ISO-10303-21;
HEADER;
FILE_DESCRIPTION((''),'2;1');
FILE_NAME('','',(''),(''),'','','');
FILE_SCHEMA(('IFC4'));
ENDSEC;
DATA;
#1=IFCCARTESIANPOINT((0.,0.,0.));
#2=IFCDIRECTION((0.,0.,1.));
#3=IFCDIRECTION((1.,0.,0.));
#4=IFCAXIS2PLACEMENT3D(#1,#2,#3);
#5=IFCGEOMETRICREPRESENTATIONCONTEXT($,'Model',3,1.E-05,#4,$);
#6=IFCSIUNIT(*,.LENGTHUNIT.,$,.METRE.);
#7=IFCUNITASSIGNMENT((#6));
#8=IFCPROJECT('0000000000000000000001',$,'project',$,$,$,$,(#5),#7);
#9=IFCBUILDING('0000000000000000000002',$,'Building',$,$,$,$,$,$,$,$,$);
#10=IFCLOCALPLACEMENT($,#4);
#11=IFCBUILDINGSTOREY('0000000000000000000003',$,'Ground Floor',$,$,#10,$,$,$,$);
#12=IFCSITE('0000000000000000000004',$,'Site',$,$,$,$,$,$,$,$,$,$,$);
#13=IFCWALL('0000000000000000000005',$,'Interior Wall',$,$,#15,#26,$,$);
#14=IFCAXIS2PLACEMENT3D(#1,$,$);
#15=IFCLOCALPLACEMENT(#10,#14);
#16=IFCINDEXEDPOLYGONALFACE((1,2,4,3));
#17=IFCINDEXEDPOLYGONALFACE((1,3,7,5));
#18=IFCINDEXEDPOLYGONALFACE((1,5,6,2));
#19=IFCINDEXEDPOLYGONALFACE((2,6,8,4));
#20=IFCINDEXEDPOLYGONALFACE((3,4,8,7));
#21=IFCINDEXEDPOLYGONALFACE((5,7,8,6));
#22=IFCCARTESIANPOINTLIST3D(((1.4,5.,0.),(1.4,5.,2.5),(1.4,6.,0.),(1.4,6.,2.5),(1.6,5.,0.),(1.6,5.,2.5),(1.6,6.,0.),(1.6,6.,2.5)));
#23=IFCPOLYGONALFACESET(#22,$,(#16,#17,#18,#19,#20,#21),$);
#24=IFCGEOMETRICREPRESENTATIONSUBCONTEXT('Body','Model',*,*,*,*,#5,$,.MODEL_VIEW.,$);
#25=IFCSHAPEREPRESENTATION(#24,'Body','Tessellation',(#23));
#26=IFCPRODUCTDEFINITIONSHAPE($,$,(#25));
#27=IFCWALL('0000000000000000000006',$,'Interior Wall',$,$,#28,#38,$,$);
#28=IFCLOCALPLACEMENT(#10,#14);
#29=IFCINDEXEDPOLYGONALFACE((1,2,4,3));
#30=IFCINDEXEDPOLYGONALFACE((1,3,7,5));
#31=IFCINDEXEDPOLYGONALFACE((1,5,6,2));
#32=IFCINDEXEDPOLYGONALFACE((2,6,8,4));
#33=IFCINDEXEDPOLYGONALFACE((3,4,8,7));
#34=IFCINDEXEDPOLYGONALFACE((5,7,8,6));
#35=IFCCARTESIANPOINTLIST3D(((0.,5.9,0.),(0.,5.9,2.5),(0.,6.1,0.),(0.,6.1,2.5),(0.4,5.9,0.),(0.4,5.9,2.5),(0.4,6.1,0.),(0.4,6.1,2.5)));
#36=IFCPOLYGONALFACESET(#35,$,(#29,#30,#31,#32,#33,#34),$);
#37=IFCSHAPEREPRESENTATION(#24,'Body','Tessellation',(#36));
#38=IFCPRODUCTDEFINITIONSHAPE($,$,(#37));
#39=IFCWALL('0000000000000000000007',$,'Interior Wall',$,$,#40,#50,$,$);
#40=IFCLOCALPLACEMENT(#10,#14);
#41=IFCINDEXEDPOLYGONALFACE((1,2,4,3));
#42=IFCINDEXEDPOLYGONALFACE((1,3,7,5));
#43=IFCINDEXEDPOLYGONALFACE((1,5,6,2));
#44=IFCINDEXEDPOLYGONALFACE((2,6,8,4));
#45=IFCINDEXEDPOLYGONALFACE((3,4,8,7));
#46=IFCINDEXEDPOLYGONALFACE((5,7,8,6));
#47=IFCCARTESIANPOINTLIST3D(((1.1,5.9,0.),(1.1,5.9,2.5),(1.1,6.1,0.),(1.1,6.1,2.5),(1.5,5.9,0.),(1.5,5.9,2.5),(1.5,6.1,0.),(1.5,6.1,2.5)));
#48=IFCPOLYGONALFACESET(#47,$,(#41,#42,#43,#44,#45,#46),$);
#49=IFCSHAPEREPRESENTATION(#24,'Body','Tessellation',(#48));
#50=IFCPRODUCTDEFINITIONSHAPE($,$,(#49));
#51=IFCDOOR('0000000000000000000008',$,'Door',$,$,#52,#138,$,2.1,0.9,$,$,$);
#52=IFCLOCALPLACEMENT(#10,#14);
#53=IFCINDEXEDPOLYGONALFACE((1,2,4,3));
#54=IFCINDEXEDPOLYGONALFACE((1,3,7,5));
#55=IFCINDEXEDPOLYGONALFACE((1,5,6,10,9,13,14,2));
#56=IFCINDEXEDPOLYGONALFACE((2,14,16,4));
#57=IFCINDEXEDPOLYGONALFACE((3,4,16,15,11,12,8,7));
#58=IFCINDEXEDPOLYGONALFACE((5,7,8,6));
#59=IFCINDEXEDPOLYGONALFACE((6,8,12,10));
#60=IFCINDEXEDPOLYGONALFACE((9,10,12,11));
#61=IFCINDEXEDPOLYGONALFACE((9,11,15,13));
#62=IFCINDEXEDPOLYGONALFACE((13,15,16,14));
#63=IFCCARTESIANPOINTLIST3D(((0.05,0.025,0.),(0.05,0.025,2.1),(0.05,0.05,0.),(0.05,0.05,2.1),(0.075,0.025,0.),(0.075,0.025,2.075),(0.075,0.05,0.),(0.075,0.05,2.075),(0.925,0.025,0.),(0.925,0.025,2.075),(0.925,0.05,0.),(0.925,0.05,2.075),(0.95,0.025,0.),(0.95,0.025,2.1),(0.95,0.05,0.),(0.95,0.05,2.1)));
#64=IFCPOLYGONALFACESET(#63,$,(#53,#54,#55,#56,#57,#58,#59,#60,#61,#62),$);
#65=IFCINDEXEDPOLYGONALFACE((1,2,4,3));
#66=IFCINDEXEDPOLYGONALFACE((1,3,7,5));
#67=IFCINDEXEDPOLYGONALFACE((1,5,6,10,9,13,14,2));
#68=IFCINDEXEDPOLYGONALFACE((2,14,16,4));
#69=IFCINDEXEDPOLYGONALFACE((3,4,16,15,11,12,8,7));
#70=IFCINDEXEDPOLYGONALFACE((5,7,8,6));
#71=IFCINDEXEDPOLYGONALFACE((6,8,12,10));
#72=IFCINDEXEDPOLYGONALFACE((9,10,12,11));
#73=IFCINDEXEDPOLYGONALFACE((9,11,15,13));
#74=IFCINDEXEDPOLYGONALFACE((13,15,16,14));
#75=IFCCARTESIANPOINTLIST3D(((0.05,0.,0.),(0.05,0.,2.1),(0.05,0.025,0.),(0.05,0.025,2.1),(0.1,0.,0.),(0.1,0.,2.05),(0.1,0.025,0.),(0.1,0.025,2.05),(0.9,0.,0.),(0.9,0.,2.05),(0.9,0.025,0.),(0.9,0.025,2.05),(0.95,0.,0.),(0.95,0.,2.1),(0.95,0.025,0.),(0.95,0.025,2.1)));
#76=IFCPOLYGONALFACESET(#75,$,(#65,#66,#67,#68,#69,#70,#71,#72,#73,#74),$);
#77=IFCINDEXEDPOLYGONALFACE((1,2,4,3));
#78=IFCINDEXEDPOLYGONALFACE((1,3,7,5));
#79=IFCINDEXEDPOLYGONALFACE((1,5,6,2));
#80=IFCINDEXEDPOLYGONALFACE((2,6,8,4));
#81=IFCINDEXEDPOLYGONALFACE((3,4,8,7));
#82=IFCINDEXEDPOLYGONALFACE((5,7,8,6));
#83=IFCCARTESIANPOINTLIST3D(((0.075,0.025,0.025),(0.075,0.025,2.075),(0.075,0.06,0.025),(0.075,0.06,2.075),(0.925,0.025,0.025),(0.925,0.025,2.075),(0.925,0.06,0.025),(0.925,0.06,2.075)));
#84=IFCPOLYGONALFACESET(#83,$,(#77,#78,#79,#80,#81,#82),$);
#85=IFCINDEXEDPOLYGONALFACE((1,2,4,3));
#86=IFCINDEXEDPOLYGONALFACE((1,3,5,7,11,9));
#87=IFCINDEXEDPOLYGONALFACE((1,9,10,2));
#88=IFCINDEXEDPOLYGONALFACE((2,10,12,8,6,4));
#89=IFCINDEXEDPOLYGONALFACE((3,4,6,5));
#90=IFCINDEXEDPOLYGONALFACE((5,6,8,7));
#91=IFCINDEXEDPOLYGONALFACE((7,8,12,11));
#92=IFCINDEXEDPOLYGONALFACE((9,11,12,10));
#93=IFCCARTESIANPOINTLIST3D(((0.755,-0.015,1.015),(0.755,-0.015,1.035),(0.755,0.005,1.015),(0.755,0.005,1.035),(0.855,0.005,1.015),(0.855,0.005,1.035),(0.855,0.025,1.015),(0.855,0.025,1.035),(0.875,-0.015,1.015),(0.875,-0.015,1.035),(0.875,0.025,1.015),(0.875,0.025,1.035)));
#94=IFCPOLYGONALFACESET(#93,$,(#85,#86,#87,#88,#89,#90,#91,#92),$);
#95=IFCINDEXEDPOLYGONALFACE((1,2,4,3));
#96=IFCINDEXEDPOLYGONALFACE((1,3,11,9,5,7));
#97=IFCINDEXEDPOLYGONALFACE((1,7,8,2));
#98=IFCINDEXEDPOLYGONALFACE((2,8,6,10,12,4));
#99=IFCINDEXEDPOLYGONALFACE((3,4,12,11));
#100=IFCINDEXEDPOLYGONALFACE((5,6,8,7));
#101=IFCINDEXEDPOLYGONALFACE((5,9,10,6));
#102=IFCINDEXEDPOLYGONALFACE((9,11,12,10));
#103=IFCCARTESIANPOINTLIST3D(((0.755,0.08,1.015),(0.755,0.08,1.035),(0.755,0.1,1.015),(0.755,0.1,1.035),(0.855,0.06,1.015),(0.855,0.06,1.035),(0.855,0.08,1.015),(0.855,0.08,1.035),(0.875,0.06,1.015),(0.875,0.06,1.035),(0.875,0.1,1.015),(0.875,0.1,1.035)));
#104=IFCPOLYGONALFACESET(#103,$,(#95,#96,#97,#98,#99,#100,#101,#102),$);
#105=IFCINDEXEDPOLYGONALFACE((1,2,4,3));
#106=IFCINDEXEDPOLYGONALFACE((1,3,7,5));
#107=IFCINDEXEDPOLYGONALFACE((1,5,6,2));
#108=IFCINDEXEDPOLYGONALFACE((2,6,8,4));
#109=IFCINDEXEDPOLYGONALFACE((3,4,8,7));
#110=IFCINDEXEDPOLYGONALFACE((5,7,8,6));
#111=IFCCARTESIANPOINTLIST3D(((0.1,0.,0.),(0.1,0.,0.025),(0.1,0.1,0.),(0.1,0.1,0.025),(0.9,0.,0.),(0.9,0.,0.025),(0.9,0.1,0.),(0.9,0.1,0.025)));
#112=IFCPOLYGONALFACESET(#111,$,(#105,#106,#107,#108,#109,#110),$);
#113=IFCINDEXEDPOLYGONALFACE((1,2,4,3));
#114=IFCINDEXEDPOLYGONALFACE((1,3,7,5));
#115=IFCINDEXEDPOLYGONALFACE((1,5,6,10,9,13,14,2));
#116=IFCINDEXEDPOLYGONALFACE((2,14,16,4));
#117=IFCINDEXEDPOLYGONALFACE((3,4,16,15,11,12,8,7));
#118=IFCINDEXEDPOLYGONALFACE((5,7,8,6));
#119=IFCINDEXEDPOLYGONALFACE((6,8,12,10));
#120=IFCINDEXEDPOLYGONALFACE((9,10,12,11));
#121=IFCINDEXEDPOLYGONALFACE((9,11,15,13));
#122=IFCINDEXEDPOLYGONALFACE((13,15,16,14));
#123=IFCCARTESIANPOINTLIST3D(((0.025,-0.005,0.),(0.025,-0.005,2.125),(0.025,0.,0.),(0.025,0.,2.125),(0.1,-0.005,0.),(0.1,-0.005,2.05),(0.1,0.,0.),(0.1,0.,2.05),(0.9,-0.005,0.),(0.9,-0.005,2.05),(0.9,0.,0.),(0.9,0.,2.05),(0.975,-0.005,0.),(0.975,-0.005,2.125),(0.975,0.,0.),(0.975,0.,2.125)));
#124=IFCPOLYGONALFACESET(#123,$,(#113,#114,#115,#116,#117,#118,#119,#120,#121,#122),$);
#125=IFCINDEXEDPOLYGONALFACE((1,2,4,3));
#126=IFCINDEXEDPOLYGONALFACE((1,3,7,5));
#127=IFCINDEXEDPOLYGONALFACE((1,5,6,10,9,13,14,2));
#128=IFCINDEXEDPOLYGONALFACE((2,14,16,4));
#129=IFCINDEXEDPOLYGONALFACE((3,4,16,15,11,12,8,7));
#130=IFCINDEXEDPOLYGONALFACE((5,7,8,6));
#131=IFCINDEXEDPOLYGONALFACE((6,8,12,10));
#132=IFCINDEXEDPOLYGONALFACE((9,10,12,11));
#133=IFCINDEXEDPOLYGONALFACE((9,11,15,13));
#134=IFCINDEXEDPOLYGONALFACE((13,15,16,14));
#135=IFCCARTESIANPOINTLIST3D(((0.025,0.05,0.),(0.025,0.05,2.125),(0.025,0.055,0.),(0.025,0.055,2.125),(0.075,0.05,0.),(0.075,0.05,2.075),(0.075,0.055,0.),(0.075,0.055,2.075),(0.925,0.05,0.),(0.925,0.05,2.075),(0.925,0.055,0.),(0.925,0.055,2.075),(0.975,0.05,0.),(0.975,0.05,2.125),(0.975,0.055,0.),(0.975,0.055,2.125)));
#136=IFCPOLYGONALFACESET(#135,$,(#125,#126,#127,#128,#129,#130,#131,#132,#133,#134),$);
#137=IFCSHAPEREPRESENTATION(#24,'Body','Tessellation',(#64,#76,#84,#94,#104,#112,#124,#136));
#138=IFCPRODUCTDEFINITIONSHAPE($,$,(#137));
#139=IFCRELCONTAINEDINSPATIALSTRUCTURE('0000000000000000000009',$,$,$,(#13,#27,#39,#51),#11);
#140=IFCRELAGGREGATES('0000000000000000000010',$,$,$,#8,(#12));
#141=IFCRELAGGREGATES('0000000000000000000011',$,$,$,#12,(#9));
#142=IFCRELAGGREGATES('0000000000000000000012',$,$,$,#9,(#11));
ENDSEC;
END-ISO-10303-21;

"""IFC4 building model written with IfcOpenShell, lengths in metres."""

from ifc_helpers import new_model, si_unit, frame, origin_with_axes, place, context, subcontext, project, spatial, line, indexed_curve, outline, extrude, element, save


model = new_model("IFC4")

# Units and contexts
model_context = context("Model", 3, precision=1e-05, world=origin_with_axes())
body_context = subcontext(model_context, "Body", "Model", "MODEL_VIEW")
ifc_project = project(units=[si_unit("LENGTHUNIT", "METRE")], contexts=[model_context])

# Site, building, storey
site = spatial("IfcSite", under=ifc_project, Name="Site")
building = spatial("IfcBuilding", under=site, Name="Building")
storey_placement = place(None, origin_with_axes())
storey = spatial("IfcBuildingStorey", under=building, at=storey_placement, Name="Ground Floor")

# Walls
wall_1_placement = place(storey_placement, frame((1.5, 6.0, 0.0), z_axis=(0.0, 0.0, 1.0), x_axis=(0.0, -1.0, 0.0)))
element("IfcWall", 1, at=wall_1_placement, inside=storey, Name="Interior Wall", context=body_context, shape_type="SweptSolid", body=[
    extrude(outline(indexed_curve([(0.0, 0.0), (0.0, 0.2), (1.0, 0.2), (1.0, 0.0), (0.0, 0.0)], self_intersect=False)), frame((0.0, -0.1, 0.0), z_axis=(0.0, 0.0, 1.0), x_axis=(1.0, 0.0, 0.0)), (0.0, 0.0, 1.0), 2.5),
])
wall_2_placement = place(storey_placement, frame((0.0, 6.0, 0.0), z_axis=(0.0, 0.0, 1.0), x_axis=(1.0, 0.0, 0.0)))
element("IfcWall", 2, at=wall_2_placement, inside=storey, Name="Interior Wall", context=body_context, shape_type="SweptSolid", body=[
    extrude(outline(indexed_curve([(0.0, 0.0), (0.0, 0.2), (0.4, 0.2), (0.4, 0.0), (0.0, 0.0)], self_intersect=False)), frame((0.0, -0.1, 0.0), z_axis=(0.0, 0.0, 1.0), x_axis=(1.0, 0.0, 0.0)), (0.0, 0.0, 1.0), 2.5),
])
wall_3_placement = place(storey_placement, frame((1.1, 6.0, 0.0), z_axis=(0.0, 0.0, 1.0), x_axis=(1.0, 0.0, 0.0)))
element("IfcWall", 3, at=wall_3_placement, inside=storey, Name="Interior Wall", context=body_context, shape_type="SweptSolid", body=[
    extrude(outline(indexed_curve([(0.0, 0.0), (0.0, 0.2), (0.4, 0.2), (0.4, 0.0), (0.0, 0.0)], self_intersect=False)), frame((0.0, -0.1, 0.0), z_axis=(0.0, 0.0, 1.0), x_axis=(1.0, 0.0, 0.0)), (0.0, 0.0, 1.0), 2.5),
])

# Door
door_1_placement = place(storey_placement, frame((0.05, 0.0, 0.0), z_axis=(0.0, 0.0, 1.0), x_axis=(1.0, 0.0, 0.0)))
element("IfcDoor", 4, at=door_1_placement, inside=storey, Name="Door", OverallHeight=2.1, OverallWidth=0.9, context=body_context, shape_type="SweptSolid", body=[
    extrude(outline(indexed_curve([(0.0, 0.0), (0.0, 2.1), (0.9, 2.1), (0.9, 0.0), (0.875, 0.0), (0.875, 2.075), (0.025, 2.075), (0.025, 0.0)], segments=[line(1, 2, 3, 4, 5, 6, 7, 8, 1)])), frame((0.0, 0.025, 0.0), z_axis=(0.0, -1.0, 0.0), x_axis=(1.0, 0.0, 0.0)), (0.0, 0.0, -1.0), 0.025),
    extrude(outline(indexed_curve([(0.0, 0.0), (0.0, 2.1), (0.9, 2.1), (0.9, 0.0), (0.85, 0.0), (0.85, 2.05), (0.05, 2.05), (0.05, 0.0)], segments=[line(1, 2, 3, 4, 5, 6, 7, 8, 1)])), frame((0.0, 0.0, 0.0), z_axis=(0.0, -1.0, 0.0), x_axis=(1.0, 0.0, 0.0)), (0.0, 0.0, -1.0), 0.025),
    extrude(outline(indexed_curve([(0.0, 0.0), (0.85, 0.0), (0.85, 0.035), (0.0, 0.035)], segments=[line(1, 2, 3, 4, 1)])), frame((0.025, 0.025, 0.025), z_axis=(0.0, 0.0, 1.0), x_axis=(1.0, 0.0, 0.0)), (0.0, 0.0, 1.0), 2.05),
    extrude(outline(indexed_curve([(0.0, 0.0), (0.0, -0.04), (-0.12, -0.04), (-0.12, -0.02), (-0.02, -0.02), (-0.02, 0.0)], segments=[line(1, 2, 3, 4, 5, 6, 1)])), frame((0.825, 0.025, 1.015), z_axis=(0.0, 0.0, 1.0), x_axis=(1.0, 0.0, 0.0)), (0.0, 0.0, 1.0), 0.02),
    extrude(outline(indexed_curve([(0.0, 0.0), (0.0, 0.04), (-0.12, 0.04), (-0.12, 0.02), (-0.02, 0.02), (-0.02, 0.0)], segments=[line(1, 2, 3, 4, 5, 6, 1)])), frame((0.825, 0.06, 1.015), z_axis=(0.0, 0.0, 1.0), x_axis=(1.0, 0.0, 0.0)), (0.0, 0.0, 1.0), 0.02),
    extrude(outline(indexed_curve([(0.0, 0.0), (0.8, 0.0), (0.8, 0.1), (0.0, 0.1)], segments=[line(1, 2, 3, 4, 1)])), frame((0.05, 0.0, 0.0), z_axis=(0.0, 0.0, 1.0), x_axis=(1.0, 0.0, 0.0)), (0.0, 0.0, 1.0), 0.025),
    extrude(outline(indexed_curve([(0.0, 0.0), (0.0, 2.125), (0.95, 2.125), (0.95, 0.0), (0.875, 0.0), (0.875, 2.05), (0.075, 2.05), (0.075, 0.0)], segments=[line(1, 2, 3, 4, 5, 6, 7, 8, 1)])), frame((-0.025, -0.005, 0.0), z_axis=(0.0, -1.0, 0.0), x_axis=(1.0, 0.0, 0.0)), (0.0, 0.0, -1.0), 0.005),
    extrude(outline(indexed_curve([(0.0, 0.0), (0.0, 2.125), (0.95, 2.125), (0.95, 0.0), (0.9, 0.0), (0.9, 2.075), (0.05, 2.075), (0.05, 0.0)], segments=[line(1, 2, 3, 4, 5, 6, 7, 8, 1)])), frame((-0.025, 0.05, 0.0), z_axis=(0.0, -1.0, 0.0), x_axis=(1.0, 0.0, 0.0)), (0.0, 0.0, -1.0), 0.005),
])

save(model, "model.ifc")
